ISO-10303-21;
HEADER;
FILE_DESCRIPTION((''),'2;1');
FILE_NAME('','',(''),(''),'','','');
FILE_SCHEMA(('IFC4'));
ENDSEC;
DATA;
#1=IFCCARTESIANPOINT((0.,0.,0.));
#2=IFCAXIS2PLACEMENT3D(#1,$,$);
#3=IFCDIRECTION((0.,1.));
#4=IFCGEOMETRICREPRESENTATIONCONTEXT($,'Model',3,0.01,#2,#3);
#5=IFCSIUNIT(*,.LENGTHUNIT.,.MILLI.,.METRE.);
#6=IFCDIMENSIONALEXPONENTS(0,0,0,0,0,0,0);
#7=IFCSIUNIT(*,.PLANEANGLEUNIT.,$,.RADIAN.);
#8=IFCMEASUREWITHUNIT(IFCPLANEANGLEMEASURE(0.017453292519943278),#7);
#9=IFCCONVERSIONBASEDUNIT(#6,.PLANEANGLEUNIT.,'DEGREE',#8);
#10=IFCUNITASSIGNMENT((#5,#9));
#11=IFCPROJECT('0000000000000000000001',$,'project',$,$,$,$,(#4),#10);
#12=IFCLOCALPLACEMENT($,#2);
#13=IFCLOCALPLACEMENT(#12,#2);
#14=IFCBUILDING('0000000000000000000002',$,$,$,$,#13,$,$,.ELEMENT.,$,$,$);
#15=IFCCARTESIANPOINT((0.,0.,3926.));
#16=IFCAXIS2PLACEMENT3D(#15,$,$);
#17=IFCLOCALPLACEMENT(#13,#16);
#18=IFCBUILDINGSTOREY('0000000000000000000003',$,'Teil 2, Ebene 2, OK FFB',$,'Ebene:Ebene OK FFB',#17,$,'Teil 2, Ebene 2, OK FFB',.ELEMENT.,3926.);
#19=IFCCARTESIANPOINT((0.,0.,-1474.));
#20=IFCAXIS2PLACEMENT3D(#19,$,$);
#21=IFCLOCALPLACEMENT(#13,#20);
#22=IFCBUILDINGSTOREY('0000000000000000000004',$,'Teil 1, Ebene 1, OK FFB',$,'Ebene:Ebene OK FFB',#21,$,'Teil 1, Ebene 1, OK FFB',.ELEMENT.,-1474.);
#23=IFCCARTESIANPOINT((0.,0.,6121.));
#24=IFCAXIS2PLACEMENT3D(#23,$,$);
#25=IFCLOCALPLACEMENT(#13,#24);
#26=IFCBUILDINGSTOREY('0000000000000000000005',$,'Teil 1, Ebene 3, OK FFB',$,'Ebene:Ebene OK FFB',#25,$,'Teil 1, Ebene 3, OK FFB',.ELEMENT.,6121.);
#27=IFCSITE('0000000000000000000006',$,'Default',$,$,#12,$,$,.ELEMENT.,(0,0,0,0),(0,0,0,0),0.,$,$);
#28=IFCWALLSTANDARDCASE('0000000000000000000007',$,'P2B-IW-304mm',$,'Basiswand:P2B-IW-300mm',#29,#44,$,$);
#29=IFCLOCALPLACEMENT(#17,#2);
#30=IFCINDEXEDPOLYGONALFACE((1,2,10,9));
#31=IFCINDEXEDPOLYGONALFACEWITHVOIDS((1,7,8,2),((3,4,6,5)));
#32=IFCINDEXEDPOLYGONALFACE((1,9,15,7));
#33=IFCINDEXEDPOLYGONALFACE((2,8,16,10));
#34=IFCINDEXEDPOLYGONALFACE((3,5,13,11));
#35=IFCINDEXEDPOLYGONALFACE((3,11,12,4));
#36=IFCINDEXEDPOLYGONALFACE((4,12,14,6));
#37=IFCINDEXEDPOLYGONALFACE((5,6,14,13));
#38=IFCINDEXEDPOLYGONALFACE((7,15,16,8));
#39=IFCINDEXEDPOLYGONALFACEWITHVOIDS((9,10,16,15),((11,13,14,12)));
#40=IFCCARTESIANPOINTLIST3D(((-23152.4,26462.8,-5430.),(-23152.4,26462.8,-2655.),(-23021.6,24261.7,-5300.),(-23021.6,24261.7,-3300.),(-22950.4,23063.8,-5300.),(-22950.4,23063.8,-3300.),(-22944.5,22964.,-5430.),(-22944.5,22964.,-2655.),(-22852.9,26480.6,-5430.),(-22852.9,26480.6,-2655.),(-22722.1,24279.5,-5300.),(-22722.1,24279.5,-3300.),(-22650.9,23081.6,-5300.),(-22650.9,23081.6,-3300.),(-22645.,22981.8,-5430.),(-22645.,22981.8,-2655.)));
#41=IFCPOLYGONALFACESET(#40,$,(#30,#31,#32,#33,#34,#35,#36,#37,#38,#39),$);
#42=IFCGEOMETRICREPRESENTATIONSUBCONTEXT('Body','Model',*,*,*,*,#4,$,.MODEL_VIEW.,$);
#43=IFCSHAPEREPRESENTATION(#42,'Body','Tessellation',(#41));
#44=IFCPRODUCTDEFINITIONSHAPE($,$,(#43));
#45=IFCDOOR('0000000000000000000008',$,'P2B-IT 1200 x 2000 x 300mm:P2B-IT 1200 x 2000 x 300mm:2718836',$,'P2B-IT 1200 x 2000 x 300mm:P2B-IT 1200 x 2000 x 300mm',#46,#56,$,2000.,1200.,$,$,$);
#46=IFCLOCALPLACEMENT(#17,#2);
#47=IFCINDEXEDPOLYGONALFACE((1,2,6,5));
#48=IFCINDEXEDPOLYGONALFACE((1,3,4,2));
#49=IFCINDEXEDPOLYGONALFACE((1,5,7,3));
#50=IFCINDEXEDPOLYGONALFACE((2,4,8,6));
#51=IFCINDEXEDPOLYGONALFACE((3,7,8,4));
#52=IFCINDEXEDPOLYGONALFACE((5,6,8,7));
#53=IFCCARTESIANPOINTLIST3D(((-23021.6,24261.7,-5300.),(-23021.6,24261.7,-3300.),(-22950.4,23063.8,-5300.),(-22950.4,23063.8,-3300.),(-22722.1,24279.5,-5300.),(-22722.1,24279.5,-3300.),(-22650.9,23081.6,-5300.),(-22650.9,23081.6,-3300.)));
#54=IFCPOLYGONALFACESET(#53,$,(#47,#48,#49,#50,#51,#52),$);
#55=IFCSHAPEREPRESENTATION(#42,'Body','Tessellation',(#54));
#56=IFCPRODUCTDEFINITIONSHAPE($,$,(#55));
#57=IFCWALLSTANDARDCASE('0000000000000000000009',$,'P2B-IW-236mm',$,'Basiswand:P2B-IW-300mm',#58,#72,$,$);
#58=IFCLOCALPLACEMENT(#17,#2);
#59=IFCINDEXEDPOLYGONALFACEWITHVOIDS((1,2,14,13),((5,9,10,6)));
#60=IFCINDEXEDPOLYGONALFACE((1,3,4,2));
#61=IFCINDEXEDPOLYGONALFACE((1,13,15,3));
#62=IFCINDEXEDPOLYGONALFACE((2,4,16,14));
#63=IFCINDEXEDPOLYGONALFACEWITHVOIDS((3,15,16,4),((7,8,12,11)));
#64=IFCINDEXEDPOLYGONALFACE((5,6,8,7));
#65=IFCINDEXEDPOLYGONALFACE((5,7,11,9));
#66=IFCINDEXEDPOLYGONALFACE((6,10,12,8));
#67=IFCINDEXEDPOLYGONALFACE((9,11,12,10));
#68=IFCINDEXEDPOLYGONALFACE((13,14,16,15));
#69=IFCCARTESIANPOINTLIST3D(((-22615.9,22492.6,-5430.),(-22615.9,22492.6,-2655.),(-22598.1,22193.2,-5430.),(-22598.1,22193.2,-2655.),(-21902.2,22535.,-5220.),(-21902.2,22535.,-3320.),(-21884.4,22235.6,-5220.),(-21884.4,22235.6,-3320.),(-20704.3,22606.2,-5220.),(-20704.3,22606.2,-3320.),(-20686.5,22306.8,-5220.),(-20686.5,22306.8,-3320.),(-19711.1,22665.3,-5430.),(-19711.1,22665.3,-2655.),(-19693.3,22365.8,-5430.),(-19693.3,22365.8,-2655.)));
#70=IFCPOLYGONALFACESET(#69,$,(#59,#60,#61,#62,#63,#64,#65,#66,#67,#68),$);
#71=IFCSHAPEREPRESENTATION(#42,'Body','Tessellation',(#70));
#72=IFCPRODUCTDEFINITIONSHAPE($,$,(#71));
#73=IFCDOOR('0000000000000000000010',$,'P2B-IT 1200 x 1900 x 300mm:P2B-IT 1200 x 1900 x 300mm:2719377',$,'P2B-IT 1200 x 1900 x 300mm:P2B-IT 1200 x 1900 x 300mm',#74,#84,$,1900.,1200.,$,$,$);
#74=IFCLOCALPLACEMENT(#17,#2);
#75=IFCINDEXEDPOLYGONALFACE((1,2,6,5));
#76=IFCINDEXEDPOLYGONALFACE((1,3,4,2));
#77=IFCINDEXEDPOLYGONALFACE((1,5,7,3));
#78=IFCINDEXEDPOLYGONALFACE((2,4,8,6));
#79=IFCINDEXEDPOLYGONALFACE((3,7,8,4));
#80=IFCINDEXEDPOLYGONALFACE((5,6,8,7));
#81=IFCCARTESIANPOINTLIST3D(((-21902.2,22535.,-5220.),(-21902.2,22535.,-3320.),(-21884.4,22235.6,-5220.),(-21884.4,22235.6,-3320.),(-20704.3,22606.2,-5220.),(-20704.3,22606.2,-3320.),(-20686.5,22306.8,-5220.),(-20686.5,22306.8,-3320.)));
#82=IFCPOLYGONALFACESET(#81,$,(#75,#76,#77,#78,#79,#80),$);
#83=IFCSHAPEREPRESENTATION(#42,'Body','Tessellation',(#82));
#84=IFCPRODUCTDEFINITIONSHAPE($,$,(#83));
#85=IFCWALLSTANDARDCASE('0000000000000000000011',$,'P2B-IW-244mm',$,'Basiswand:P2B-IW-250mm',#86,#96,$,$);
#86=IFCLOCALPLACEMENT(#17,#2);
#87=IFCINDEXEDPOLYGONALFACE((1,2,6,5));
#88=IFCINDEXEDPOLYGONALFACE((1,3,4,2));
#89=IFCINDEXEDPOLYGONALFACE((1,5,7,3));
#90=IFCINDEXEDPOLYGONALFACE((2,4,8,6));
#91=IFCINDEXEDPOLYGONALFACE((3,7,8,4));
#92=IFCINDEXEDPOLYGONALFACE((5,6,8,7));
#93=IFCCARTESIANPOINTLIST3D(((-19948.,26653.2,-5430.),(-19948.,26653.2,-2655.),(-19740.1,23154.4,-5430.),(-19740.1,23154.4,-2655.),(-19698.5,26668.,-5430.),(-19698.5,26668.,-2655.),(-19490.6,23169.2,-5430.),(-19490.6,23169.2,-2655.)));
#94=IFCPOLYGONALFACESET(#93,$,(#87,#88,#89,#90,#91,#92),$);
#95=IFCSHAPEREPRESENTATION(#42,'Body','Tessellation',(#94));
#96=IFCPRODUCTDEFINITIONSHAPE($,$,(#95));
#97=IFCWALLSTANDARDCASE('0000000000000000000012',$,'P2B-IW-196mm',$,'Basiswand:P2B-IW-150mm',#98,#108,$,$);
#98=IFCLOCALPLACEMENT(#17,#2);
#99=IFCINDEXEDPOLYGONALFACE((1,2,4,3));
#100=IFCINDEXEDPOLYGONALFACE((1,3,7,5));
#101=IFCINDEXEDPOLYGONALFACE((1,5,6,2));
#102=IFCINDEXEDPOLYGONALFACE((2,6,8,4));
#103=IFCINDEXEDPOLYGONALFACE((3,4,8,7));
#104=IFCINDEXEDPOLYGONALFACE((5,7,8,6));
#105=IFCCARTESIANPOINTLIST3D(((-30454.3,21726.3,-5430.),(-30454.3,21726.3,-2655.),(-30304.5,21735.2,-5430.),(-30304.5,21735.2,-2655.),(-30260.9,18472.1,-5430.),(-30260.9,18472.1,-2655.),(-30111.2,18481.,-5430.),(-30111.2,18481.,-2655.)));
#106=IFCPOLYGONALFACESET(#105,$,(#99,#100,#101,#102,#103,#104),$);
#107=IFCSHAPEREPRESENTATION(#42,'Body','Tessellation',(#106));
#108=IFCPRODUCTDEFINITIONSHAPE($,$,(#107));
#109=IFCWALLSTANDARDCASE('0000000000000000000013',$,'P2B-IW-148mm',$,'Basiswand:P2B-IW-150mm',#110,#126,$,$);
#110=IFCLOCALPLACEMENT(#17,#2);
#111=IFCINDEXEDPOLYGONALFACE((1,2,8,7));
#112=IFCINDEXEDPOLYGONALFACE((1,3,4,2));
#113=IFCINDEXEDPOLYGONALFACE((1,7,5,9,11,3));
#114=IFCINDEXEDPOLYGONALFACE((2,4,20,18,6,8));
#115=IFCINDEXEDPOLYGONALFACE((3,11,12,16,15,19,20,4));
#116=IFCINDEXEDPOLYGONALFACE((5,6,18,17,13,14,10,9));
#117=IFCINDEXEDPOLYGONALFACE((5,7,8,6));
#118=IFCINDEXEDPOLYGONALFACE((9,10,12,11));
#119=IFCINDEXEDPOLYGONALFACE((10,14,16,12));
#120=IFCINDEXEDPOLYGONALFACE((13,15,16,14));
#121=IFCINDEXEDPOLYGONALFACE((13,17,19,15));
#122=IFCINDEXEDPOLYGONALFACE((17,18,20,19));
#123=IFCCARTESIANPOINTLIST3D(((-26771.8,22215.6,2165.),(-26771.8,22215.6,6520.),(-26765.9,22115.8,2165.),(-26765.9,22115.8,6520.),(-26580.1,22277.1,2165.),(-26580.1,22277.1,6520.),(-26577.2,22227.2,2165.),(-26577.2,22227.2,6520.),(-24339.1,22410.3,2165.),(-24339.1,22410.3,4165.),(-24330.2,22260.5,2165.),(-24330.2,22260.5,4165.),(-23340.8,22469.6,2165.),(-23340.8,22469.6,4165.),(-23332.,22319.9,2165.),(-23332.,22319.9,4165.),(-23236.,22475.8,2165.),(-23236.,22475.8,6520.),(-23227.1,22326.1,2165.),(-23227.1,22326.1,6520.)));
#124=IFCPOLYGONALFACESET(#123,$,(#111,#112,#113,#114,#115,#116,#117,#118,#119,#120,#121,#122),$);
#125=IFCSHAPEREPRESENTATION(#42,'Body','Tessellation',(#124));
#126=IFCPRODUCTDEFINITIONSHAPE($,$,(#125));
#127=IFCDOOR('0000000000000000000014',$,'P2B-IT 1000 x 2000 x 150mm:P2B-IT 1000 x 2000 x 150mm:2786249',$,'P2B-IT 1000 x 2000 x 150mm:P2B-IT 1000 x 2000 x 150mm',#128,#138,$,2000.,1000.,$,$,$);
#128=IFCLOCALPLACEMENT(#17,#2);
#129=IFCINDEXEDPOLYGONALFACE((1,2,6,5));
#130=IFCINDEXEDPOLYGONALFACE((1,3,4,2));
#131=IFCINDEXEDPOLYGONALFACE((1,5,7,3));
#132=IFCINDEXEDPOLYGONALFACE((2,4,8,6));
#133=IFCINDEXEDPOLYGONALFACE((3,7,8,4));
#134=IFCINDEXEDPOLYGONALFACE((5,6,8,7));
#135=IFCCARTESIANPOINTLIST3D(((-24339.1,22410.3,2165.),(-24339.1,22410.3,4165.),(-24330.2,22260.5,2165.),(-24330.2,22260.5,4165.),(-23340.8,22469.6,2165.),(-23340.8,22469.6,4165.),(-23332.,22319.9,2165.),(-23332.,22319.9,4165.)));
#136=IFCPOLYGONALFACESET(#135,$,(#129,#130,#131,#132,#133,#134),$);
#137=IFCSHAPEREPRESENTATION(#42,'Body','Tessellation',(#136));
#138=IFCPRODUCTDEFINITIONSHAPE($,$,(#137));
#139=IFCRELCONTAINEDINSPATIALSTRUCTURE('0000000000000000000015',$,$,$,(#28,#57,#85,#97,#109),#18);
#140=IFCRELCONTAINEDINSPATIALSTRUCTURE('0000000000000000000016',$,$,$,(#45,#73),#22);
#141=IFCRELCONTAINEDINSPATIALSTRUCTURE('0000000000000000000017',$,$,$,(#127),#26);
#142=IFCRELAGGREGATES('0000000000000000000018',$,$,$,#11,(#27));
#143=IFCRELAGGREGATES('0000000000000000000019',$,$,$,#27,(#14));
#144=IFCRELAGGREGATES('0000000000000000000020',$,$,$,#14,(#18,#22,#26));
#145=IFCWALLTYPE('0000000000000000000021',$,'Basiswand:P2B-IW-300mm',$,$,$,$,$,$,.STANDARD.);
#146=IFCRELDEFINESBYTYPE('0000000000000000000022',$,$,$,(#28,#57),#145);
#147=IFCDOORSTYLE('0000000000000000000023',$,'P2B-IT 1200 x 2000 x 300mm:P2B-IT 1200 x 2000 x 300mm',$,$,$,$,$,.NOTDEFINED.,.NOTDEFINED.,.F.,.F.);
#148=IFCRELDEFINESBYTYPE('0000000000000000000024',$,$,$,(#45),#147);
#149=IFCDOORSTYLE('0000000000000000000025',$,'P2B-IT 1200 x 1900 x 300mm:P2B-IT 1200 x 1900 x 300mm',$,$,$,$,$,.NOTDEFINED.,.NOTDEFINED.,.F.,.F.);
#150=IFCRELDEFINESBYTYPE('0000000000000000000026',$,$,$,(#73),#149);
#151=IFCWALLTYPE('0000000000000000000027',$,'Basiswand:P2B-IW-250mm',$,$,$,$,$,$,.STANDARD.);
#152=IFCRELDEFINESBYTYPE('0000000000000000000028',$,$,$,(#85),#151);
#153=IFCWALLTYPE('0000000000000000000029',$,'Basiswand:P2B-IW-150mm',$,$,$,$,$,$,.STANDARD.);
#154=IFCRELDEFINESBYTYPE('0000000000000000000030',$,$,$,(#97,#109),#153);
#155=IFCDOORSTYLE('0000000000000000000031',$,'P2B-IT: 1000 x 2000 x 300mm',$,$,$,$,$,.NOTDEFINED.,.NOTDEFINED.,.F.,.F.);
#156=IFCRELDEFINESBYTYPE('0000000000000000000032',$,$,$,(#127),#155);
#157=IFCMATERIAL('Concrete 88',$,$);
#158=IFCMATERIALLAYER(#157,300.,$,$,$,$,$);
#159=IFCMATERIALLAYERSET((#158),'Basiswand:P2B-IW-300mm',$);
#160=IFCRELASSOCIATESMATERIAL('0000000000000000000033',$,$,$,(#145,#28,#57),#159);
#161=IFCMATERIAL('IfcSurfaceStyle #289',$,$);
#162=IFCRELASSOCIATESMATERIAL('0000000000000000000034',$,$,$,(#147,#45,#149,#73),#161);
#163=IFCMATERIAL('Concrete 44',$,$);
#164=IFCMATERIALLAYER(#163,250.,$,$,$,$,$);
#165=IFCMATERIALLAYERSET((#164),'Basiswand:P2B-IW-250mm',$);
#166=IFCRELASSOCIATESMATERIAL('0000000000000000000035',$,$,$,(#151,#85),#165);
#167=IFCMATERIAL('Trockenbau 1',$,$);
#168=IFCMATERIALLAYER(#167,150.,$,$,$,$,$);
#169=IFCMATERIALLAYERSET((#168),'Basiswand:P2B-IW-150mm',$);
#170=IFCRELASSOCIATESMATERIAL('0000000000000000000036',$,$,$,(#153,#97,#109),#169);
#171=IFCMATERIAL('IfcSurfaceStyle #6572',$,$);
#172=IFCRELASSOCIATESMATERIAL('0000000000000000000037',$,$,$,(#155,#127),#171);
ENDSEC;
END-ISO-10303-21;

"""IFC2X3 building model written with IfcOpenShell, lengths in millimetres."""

from ifc_helpers import new_model, entity, si_unit, converted_unit, direction, frame, frame_2d, origin, origin_2d_with_axis, place, context, subcontext, project, spatial, polyline, rectangle, extrude, clip, bounded_halfspace, source, transform, mapped, material, layer, layer_set, layer_usage, type_object, type_shapes, element, fill, save


model = new_model("IFC2X3")

# Units and contexts
model_context = context("Model", 3, precision=0.01, world=origin(), true_north=direction((0.0, 1.0)))
body_context = subcontext(model_context, "Body", "Model", "MODEL_VIEW")
ifc_project = project(units=[si_unit("LENGTHUNIT", "METRE", prefix="MILLI"), converted_unit("PLANEANGLEUNIT", "DEGREE", entity("IfcPlaneAngleMeasure", 0.017453292519943278), si_unit("PLANEANGLEUNIT", "RADIAN"), dimensions=[0, 0, 0, 0, 0, 0, 0])], contexts=[model_context])

# Site, building, storey
site_placement = place(None, origin())
site = spatial("IfcSite", under=ifc_project, at=site_placement, Name="Default", CompositionType="ELEMENT", RefLatitude=(0, 0, 0, 0), RefLongitude=(0, 0, 0, 0), RefElevation=0.0)
building_placement = place(site_placement, origin())
building = spatial("IfcBuilding", under=site, at=building_placement, CompositionType="ELEMENT")
storey_1_placement = place(building_placement, frame((0.0, 0.0, 3926.0)))
storey_1 = spatial("IfcBuildingStorey", under=building, at=storey_1_placement, Name="Teil 2, Ebene 2, OK FFB", ObjectType="Ebene:Ebene OK FFB", LongName="Teil 2, Ebene 2, OK FFB", CompositionType="ELEMENT", Elevation=3926.0)

# Wall, opening
ifc_material_1 = material(Name="Concrete 88")
ifc_layer_1 = layer(ifc_material_1, 300.0)
ifc_layer_set_1 = layer_set([ifc_layer_1], Name="Basiswand:P2B-IW-300mm")
ifc_layer_usage_1 = layer_usage(ifc_layer_set_1, "AXIS2", "NEGATIVE", 150.0)
wall_type_1 = type_object("IfcWallType", Name="Basiswand:P2B-IW-300mm", PredefinedType="STANDARD", material=ifc_layer_set_1)
wall_1_placement = place(storey_1_placement, frame((-22794.7, 22972.9, -5430.0), z_axis=(0.0, 0.0, 1.0), x_axis=(-0.059319, 0.998239, 0.0)))
wall_1 = element("IfcWallStandardCase", 1, at=wall_1_placement, inside=storey_1, type_object=wall_type_1, material=ifc_layer_usage_1, Name="P2B-IW-304mm", ObjectType="Basiswand:P2B-IW-300mm", context=body_context, shape_type="SweptSolid", body=[
    extrude(rectangle(XDim=3505.0, YDim=300.0, at=frame_2d((1752.5, 0.0), x_axis=(-1.0, 0.0))), origin(), (0.0, 0.0, 1.0), 2775.0),
])
opening_1_placement = place(wall_1_placement, frame((-24284.6, -21391.9, 30.0), z_axis=(0.0, 0.0, 1.0), x_axis=(-0.059319, -0.998239, 0.0)))
opening_1 = element("IfcOpeningElement", 2, at=opening_1_placement, cuts=wall_1, ObjectType="Opening", context=body_context, shape_type="SweptSolid", body=[
    extrude(rectangle(XDim=2000.0, YDim=1200.0, at=frame_2d((0.0, 0.0), x_axis=(1.0, 0.0))), frame((-22686.5, 23680.5, 1100.0), z_axis=(-0.998239, -0.059319, 0.0), x_axis=(0.0, 0.0, -1.0)), (0.0, 0.0, 1.0), 300.0),
])

# Shared definitions
storey_2_placement = place(building_placement, frame((0.0, 0.0, -1474.0)))
storey_2 = spatial("IfcBuildingStorey", under=building, at=storey_2_placement, Name="Teil 1, Ebene 1, OK FFB", ObjectType="Ebene:Ebene OK FFB", LongName="Teil 1, Ebene 1, OK FFB", CompositionType="ELEMENT", Elevation=-1474.0)

# Door
ifc_material_2 = material(Name="IfcSurfaceStyle #289")
door_style_1 = type_object("IfcDoorStyle", Name="P2B-IT 1200 x 2000 x 300mm:P2B-IT 1200 x 2000 x 300mm", ConstructionType="NOTDEFINED", OperationType="NOTDEFINED", ParameterTakesPrecedence=False, Sizeable=False, material=ifc_material_2)
shared_shape_1 = source(origin(), body_context, "Body", "SweptSolid", [
    extrude(rectangle(XDim=300.0, YDim=1200.0, at=frame_2d((0.0, 0.0), x_axis=(1.0, 0.0))), frame((600.0, 150.0, 0.0), z_axis=(0.0, 0.0, 1.0), x_axis=(0.0, 1.0, 0.0)), (0.0, 0.0, 1.0), 2000.0),
])
type_shapes(door_style_1, [shared_shape_1])
door_1_placement = place(opening_1_placement, frame((-23021.6, 24261.7, 100.0), z_axis=(0.0, 0.0, 1.0), x_axis=(0.059319, -0.998239, 0.0)))
door_1 = element("IfcDoor", 3, at=door_1_placement, inside=storey_2, type_object=door_style_1, material=ifc_material_2, Name="P2B-IT 1200 x 2000 x 300mm:P2B-IT 1200 x 2000 x 300mm:2718836", ObjectType="P2B-IT 1200 x 2000 x 300mm:P2B-IT 1200 x 2000 x 300mm", OverallHeight=2000.0, OverallWidth=1200.0, context=body_context, shape_type="MappedRepresentation", body=[
    mapped(shared_shape_1, transform((0.0, 0.0, 0.0), scale=1.0)),
])
fill(opening_1, door_1)

# Wall, opening, door
ifc_layer_usage_2 = layer_usage(ifc_layer_set_1, "AXIS2", "POSITIVE", -150.0)
wall_2_placement = place(storey_1_placement, frame((-19702.2, 22515.5, -5430.0), z_axis=(0.0, 0.0, 1.0), x_axis=(-0.998239, -0.059319, 0.0)))
wall_2 = element("IfcWallStandardCase", 4, at=wall_2_placement, inside=storey_1, type_object=wall_type_1, material=ifc_layer_usage_2, Name="P2B-IW-236mm", ObjectType="Basiswand:P2B-IW-300mm", context=body_context, shape_type="SweptSolid", body=[
    extrude(rectangle(XDim=2910.0, YDim=300.0, at=frame_2d((1455.0, 0.0), x_axis=(-1.0, 0.0))), origin(), (0.0, 0.0, 1.0), 2775.0),
])
opening_2_placement = place(wall_2_placement, frame((-18331.9, 23644.6, 30.0), z_axis=(0.0, 0.0, 1.0), x_axis=(-0.998239, 0.059319, 0.0)))
opening_2 = element("IfcOpeningElement", 5, at=opening_2_placement, cuts=wall_2, ObjectType="Opening", context=body_context, shape_type="SweptSolid", body=[
    extrude(rectangle(XDim=1900.0, YDim=1200.0, at=frame_2d((0.0, 0.0), x_axis=(1.0, 0.0))), frame((-21303.3, 22570.6, 1130.0), z_axis=(0.059319, -0.998239, 0.0), x_axis=(0.0, 0.0, -1.0)), (0.0, 0.0, 1.0), 300.0),
])
door_style_2 = type_object("IfcDoorStyle", Name="P2B-IT 1200 x 1900 x 300mm:P2B-IT 1200 x 1900 x 300mm", ConstructionType="NOTDEFINED", OperationType="NOTDEFINED", ParameterTakesPrecedence=False, Sizeable=False, material=ifc_material_2)
shared_shape_2 = source(origin(), body_context, "Body", "SweptSolid", [
    extrude(rectangle(XDim=300.0, YDim=1200.0, at=frame_2d((0.0, 0.0), x_axis=(1.0, 0.0))), frame((600.0, 150.0, 0.0), z_axis=(0.0, 0.0, 1.0), x_axis=(0.0, 1.0, 0.0)), (0.0, 0.0, 1.0), 1900.0),
])
type_shapes(door_style_2, [shared_shape_2])
door_2_placement = place(opening_2_placement, frame((-21884.4, 22235.6, 180.0), z_axis=(0.0, 0.0, 1.0), x_axis=(0.998239, 0.059319, 0.0)))
door_2 = element("IfcDoor", 6, at=door_2_placement, inside=storey_2, type_object=door_style_2, material=ifc_material_2, Name="P2B-IT 1200 x 1900 x 300mm:P2B-IT 1200 x 1900 x 300mm:2719377", ObjectType="P2B-IT 1200 x 1900 x 300mm:P2B-IT 1200 x 1900 x 300mm", OverallHeight=1900.0, OverallWidth=1200.0, context=body_context, shape_type="MappedRepresentation", body=[
    mapped(shared_shape_2, transform((0.0, 0.0, 0.0), scale=1.0)),
])
fill(opening_2, door_2)

# Walls
ifc_material_3 = material(Name="Concrete 44")
ifc_layer_2 = layer(ifc_material_3, 250.0)
ifc_layer_set_2 = layer_set([ifc_layer_2], Name="Basiswand:P2B-IW-250mm")
ifc_layer_usage_3 = layer_usage(ifc_layer_set_2, "AXIS2", "POSITIVE", -125.0)
wall_type_2 = type_object("IfcWallType", Name="Basiswand:P2B-IW-250mm", PredefinedType="STANDARD", material=ifc_layer_set_2)
wall_3_placement = place(storey_1_placement, frame((-19615.4, 23161.8, -5430.0), z_axis=(0.0, 0.0, 1.0), x_axis=(-0.059319, 0.998239, 0.0)))
element("IfcWallStandardCase", 7, at=wall_3_placement, inside=storey_1, type_object=wall_type_2, material=ifc_layer_usage_3, Name="P2B-IW-244mm", ObjectType="Basiswand:P2B-IW-250mm", context=body_context, shape_type="SweptSolid", body=[
    extrude(rectangle(XDim=3505.0, YDim=250.0, at=frame_2d((1752.5, 0.0), x_axis=(-1.0, 0.0))), origin(), (0.0, 0.0, 1.0), 2775.0),
])
ifc_material_4 = material(Name="Trockenbau 1")
ifc_layer_3 = layer(ifc_material_4, 150.0)
ifc_layer_set_3 = layer_set([ifc_layer_3], Name="Basiswand:P2B-IW-150mm")
ifc_layer_usage_4 = layer_usage(ifc_layer_set_3, "AXIS2", "NEGATIVE", 75.0)
wall_type_3 = type_object("IfcWallType", Name="Basiswand:P2B-IW-150mm", PredefinedType="STANDARD", material=ifc_layer_set_3)
wall_4_placement = place(storey_1_placement, frame((-30186.0, 18476.5, -5430.0), z_axis=(0.0, 0.0, 1.0), x_axis=(-0.059319, 0.998239, 0.0)))
element("IfcWallStandardCase", 8, at=wall_4_placement, inside=storey_1, type_object=wall_type_3, material=ifc_layer_usage_4, Name="P2B-IW-196mm", ObjectType="Basiswand:P2B-IW-150mm", context=body_context, shape_type="SweptSolid", body=[
    extrude(rectangle(XDim=3260.0, YDim=150.0, at=frame_2d((1630.0, 0.0), x_axis=(-1.0, 0.0))), origin(), (0.0, 0.0, 1.0), 2775.0),
])

# Wall, opening
ifc_layer_usage_5 = layer_usage(ifc_layer_set_3, "AXIS2", "POSITIVE", -75.0)
wall_5_placement = place(storey_1_placement, frame((-23231.6, 22401.0, 2165.0), z_axis=(0.0, 0.0, 1.0), x_axis=(-0.998239, -0.059319, 0.0)))
wall_5 = element("IfcWallStandardCase", 9, at=wall_5_placement, inside=storey_1, type_object=wall_type_3, material=ifc_layer_usage_5, Name="P2B-IW-148mm", ObjectType="Basiswand:P2B-IW-150mm", context=body_context, shape_type="Clipping", body=[
    clip(clip(extrude(rectangle(XDim=3545.0, YDim=150.0, at=frame_2d((1772.5, 0.0), x_axis=(-1.0, 0.0))), origin(), (0.0, 0.0, 1.0), 4355.0), bounded_halfspace(frame((3350.0, -25.0, 4355.0), z_axis=(0.0, 1.0, 0.0), x_axis=(0.0, 0.0, -1.0)), True, frame((3350.0, -25.0, 4355.0), z_axis=(0.0, 1.0, 0.0), x_axis=(0.0, 0.0, -1.0)), polyline([(0.0, 0.0), (0.0, -195.0), (4355.0, -195.0), (4355.0, 0.0), (0.0, 0.0)]))), bounded_halfspace(frame((3350.0, -25.0, 0.0), z_axis=(-1.0, 0.0, 0.0), x_axis=(0.0, 0.0, -1.0)), True, frame((3350.0, -25.0, 0.0), z_axis=(-1.0, 0.0, 0.0), x_axis=(0.0, 0.0, -1.0)), polyline([(0.0, 0.0), (0.0, 50.0), (-4355.0, 50.0), (-4355.0, 0.0), (0.0, 0.0)]))),
])
opening_3_placement = place(wall_5_placement, frame((-21861.9, 23739.6, 30.0), z_axis=(0.0, 0.0, 1.0), x_axis=(-0.998239, 0.059319, 0.0)))
opening_3 = element("IfcOpeningElement", 10, at=opening_3_placement, cuts=wall_5, ObjectType="Opening", context=body_context, shape_type="SweptSolid", body=[
    extrude(rectangle(XDim=2000.0, YDim=1000.0, at=frame_2d((0.0, 0.0), x_axis=(1.0, 0.0))), frame((-23844.4, 22514.8, 970.0), z_axis=(0.059319, -0.998239, 0.0), x_axis=(0.0, 0.0, -1.0)), (0.0, 0.0, 1.0), 300.0),
])

# Shared definitions
storey_3_placement = place(building_placement, frame((0.0, 0.0, 6121.0)))
storey_3 = spatial("IfcBuildingStorey", under=building, at=storey_3_placement, Name="Teil 1, Ebene 3, OK FFB", ObjectType="Ebene:Ebene OK FFB", LongName="Teil 1, Ebene 3, OK FFB", CompositionType="ELEMENT", Elevation=6121.0)

# Door
ifc_material_5 = material(Name="IfcSurfaceStyle #6572")
door_style_3 = type_object("IfcDoorStyle", Name="P2B-IT: 1000 x 2000 x 300mm", ConstructionType="NOTDEFINED", OperationType="NOTDEFINED", ParameterTakesPrecedence=False, Sizeable=False, material=ifc_material_5)
shared_shape_3 = source(origin(), body_context, "Body", "SweptSolid", [
    extrude(rectangle(XDim=150.0, YDim=1000.0, at=origin_2d_with_axis()), frame((500.0, 150.0, 0.0), z_axis=(0.0, 0.0, 1.0), x_axis=(0.0, 1.0, 0.0)), (0.0, 0.0, 1.0), 2000.0),
])
type_shapes(door_style_3, [shared_shape_3])
door_3_placement = place(opening_3_placement, frame((-24325.7, 22185.7, -30.0), z_axis=(0.0, 0.0, 1.0), x_axis=(0.998239, 0.059319, 0.0)))
door_3 = element("IfcDoor", 11, at=door_3_placement, inside=storey_3, type_object=door_style_3, material=ifc_material_5, Name="P2B-IT 1000 x 2000 x 150mm:P2B-IT 1000 x 2000 x 150mm:2786249", ObjectType="P2B-IT 1000 x 2000 x 150mm:P2B-IT 1000 x 2000 x 150mm", OverallHeight=2000.0, OverallWidth=1000.0, context=body_context, shape_type="MappedRepresentation", body=[
    mapped(shared_shape_3, transform((0.0, 0.0, 0.0), scale=1.0)),
])
fill(opening_3, door_3)

save(model, "model.ifc")
